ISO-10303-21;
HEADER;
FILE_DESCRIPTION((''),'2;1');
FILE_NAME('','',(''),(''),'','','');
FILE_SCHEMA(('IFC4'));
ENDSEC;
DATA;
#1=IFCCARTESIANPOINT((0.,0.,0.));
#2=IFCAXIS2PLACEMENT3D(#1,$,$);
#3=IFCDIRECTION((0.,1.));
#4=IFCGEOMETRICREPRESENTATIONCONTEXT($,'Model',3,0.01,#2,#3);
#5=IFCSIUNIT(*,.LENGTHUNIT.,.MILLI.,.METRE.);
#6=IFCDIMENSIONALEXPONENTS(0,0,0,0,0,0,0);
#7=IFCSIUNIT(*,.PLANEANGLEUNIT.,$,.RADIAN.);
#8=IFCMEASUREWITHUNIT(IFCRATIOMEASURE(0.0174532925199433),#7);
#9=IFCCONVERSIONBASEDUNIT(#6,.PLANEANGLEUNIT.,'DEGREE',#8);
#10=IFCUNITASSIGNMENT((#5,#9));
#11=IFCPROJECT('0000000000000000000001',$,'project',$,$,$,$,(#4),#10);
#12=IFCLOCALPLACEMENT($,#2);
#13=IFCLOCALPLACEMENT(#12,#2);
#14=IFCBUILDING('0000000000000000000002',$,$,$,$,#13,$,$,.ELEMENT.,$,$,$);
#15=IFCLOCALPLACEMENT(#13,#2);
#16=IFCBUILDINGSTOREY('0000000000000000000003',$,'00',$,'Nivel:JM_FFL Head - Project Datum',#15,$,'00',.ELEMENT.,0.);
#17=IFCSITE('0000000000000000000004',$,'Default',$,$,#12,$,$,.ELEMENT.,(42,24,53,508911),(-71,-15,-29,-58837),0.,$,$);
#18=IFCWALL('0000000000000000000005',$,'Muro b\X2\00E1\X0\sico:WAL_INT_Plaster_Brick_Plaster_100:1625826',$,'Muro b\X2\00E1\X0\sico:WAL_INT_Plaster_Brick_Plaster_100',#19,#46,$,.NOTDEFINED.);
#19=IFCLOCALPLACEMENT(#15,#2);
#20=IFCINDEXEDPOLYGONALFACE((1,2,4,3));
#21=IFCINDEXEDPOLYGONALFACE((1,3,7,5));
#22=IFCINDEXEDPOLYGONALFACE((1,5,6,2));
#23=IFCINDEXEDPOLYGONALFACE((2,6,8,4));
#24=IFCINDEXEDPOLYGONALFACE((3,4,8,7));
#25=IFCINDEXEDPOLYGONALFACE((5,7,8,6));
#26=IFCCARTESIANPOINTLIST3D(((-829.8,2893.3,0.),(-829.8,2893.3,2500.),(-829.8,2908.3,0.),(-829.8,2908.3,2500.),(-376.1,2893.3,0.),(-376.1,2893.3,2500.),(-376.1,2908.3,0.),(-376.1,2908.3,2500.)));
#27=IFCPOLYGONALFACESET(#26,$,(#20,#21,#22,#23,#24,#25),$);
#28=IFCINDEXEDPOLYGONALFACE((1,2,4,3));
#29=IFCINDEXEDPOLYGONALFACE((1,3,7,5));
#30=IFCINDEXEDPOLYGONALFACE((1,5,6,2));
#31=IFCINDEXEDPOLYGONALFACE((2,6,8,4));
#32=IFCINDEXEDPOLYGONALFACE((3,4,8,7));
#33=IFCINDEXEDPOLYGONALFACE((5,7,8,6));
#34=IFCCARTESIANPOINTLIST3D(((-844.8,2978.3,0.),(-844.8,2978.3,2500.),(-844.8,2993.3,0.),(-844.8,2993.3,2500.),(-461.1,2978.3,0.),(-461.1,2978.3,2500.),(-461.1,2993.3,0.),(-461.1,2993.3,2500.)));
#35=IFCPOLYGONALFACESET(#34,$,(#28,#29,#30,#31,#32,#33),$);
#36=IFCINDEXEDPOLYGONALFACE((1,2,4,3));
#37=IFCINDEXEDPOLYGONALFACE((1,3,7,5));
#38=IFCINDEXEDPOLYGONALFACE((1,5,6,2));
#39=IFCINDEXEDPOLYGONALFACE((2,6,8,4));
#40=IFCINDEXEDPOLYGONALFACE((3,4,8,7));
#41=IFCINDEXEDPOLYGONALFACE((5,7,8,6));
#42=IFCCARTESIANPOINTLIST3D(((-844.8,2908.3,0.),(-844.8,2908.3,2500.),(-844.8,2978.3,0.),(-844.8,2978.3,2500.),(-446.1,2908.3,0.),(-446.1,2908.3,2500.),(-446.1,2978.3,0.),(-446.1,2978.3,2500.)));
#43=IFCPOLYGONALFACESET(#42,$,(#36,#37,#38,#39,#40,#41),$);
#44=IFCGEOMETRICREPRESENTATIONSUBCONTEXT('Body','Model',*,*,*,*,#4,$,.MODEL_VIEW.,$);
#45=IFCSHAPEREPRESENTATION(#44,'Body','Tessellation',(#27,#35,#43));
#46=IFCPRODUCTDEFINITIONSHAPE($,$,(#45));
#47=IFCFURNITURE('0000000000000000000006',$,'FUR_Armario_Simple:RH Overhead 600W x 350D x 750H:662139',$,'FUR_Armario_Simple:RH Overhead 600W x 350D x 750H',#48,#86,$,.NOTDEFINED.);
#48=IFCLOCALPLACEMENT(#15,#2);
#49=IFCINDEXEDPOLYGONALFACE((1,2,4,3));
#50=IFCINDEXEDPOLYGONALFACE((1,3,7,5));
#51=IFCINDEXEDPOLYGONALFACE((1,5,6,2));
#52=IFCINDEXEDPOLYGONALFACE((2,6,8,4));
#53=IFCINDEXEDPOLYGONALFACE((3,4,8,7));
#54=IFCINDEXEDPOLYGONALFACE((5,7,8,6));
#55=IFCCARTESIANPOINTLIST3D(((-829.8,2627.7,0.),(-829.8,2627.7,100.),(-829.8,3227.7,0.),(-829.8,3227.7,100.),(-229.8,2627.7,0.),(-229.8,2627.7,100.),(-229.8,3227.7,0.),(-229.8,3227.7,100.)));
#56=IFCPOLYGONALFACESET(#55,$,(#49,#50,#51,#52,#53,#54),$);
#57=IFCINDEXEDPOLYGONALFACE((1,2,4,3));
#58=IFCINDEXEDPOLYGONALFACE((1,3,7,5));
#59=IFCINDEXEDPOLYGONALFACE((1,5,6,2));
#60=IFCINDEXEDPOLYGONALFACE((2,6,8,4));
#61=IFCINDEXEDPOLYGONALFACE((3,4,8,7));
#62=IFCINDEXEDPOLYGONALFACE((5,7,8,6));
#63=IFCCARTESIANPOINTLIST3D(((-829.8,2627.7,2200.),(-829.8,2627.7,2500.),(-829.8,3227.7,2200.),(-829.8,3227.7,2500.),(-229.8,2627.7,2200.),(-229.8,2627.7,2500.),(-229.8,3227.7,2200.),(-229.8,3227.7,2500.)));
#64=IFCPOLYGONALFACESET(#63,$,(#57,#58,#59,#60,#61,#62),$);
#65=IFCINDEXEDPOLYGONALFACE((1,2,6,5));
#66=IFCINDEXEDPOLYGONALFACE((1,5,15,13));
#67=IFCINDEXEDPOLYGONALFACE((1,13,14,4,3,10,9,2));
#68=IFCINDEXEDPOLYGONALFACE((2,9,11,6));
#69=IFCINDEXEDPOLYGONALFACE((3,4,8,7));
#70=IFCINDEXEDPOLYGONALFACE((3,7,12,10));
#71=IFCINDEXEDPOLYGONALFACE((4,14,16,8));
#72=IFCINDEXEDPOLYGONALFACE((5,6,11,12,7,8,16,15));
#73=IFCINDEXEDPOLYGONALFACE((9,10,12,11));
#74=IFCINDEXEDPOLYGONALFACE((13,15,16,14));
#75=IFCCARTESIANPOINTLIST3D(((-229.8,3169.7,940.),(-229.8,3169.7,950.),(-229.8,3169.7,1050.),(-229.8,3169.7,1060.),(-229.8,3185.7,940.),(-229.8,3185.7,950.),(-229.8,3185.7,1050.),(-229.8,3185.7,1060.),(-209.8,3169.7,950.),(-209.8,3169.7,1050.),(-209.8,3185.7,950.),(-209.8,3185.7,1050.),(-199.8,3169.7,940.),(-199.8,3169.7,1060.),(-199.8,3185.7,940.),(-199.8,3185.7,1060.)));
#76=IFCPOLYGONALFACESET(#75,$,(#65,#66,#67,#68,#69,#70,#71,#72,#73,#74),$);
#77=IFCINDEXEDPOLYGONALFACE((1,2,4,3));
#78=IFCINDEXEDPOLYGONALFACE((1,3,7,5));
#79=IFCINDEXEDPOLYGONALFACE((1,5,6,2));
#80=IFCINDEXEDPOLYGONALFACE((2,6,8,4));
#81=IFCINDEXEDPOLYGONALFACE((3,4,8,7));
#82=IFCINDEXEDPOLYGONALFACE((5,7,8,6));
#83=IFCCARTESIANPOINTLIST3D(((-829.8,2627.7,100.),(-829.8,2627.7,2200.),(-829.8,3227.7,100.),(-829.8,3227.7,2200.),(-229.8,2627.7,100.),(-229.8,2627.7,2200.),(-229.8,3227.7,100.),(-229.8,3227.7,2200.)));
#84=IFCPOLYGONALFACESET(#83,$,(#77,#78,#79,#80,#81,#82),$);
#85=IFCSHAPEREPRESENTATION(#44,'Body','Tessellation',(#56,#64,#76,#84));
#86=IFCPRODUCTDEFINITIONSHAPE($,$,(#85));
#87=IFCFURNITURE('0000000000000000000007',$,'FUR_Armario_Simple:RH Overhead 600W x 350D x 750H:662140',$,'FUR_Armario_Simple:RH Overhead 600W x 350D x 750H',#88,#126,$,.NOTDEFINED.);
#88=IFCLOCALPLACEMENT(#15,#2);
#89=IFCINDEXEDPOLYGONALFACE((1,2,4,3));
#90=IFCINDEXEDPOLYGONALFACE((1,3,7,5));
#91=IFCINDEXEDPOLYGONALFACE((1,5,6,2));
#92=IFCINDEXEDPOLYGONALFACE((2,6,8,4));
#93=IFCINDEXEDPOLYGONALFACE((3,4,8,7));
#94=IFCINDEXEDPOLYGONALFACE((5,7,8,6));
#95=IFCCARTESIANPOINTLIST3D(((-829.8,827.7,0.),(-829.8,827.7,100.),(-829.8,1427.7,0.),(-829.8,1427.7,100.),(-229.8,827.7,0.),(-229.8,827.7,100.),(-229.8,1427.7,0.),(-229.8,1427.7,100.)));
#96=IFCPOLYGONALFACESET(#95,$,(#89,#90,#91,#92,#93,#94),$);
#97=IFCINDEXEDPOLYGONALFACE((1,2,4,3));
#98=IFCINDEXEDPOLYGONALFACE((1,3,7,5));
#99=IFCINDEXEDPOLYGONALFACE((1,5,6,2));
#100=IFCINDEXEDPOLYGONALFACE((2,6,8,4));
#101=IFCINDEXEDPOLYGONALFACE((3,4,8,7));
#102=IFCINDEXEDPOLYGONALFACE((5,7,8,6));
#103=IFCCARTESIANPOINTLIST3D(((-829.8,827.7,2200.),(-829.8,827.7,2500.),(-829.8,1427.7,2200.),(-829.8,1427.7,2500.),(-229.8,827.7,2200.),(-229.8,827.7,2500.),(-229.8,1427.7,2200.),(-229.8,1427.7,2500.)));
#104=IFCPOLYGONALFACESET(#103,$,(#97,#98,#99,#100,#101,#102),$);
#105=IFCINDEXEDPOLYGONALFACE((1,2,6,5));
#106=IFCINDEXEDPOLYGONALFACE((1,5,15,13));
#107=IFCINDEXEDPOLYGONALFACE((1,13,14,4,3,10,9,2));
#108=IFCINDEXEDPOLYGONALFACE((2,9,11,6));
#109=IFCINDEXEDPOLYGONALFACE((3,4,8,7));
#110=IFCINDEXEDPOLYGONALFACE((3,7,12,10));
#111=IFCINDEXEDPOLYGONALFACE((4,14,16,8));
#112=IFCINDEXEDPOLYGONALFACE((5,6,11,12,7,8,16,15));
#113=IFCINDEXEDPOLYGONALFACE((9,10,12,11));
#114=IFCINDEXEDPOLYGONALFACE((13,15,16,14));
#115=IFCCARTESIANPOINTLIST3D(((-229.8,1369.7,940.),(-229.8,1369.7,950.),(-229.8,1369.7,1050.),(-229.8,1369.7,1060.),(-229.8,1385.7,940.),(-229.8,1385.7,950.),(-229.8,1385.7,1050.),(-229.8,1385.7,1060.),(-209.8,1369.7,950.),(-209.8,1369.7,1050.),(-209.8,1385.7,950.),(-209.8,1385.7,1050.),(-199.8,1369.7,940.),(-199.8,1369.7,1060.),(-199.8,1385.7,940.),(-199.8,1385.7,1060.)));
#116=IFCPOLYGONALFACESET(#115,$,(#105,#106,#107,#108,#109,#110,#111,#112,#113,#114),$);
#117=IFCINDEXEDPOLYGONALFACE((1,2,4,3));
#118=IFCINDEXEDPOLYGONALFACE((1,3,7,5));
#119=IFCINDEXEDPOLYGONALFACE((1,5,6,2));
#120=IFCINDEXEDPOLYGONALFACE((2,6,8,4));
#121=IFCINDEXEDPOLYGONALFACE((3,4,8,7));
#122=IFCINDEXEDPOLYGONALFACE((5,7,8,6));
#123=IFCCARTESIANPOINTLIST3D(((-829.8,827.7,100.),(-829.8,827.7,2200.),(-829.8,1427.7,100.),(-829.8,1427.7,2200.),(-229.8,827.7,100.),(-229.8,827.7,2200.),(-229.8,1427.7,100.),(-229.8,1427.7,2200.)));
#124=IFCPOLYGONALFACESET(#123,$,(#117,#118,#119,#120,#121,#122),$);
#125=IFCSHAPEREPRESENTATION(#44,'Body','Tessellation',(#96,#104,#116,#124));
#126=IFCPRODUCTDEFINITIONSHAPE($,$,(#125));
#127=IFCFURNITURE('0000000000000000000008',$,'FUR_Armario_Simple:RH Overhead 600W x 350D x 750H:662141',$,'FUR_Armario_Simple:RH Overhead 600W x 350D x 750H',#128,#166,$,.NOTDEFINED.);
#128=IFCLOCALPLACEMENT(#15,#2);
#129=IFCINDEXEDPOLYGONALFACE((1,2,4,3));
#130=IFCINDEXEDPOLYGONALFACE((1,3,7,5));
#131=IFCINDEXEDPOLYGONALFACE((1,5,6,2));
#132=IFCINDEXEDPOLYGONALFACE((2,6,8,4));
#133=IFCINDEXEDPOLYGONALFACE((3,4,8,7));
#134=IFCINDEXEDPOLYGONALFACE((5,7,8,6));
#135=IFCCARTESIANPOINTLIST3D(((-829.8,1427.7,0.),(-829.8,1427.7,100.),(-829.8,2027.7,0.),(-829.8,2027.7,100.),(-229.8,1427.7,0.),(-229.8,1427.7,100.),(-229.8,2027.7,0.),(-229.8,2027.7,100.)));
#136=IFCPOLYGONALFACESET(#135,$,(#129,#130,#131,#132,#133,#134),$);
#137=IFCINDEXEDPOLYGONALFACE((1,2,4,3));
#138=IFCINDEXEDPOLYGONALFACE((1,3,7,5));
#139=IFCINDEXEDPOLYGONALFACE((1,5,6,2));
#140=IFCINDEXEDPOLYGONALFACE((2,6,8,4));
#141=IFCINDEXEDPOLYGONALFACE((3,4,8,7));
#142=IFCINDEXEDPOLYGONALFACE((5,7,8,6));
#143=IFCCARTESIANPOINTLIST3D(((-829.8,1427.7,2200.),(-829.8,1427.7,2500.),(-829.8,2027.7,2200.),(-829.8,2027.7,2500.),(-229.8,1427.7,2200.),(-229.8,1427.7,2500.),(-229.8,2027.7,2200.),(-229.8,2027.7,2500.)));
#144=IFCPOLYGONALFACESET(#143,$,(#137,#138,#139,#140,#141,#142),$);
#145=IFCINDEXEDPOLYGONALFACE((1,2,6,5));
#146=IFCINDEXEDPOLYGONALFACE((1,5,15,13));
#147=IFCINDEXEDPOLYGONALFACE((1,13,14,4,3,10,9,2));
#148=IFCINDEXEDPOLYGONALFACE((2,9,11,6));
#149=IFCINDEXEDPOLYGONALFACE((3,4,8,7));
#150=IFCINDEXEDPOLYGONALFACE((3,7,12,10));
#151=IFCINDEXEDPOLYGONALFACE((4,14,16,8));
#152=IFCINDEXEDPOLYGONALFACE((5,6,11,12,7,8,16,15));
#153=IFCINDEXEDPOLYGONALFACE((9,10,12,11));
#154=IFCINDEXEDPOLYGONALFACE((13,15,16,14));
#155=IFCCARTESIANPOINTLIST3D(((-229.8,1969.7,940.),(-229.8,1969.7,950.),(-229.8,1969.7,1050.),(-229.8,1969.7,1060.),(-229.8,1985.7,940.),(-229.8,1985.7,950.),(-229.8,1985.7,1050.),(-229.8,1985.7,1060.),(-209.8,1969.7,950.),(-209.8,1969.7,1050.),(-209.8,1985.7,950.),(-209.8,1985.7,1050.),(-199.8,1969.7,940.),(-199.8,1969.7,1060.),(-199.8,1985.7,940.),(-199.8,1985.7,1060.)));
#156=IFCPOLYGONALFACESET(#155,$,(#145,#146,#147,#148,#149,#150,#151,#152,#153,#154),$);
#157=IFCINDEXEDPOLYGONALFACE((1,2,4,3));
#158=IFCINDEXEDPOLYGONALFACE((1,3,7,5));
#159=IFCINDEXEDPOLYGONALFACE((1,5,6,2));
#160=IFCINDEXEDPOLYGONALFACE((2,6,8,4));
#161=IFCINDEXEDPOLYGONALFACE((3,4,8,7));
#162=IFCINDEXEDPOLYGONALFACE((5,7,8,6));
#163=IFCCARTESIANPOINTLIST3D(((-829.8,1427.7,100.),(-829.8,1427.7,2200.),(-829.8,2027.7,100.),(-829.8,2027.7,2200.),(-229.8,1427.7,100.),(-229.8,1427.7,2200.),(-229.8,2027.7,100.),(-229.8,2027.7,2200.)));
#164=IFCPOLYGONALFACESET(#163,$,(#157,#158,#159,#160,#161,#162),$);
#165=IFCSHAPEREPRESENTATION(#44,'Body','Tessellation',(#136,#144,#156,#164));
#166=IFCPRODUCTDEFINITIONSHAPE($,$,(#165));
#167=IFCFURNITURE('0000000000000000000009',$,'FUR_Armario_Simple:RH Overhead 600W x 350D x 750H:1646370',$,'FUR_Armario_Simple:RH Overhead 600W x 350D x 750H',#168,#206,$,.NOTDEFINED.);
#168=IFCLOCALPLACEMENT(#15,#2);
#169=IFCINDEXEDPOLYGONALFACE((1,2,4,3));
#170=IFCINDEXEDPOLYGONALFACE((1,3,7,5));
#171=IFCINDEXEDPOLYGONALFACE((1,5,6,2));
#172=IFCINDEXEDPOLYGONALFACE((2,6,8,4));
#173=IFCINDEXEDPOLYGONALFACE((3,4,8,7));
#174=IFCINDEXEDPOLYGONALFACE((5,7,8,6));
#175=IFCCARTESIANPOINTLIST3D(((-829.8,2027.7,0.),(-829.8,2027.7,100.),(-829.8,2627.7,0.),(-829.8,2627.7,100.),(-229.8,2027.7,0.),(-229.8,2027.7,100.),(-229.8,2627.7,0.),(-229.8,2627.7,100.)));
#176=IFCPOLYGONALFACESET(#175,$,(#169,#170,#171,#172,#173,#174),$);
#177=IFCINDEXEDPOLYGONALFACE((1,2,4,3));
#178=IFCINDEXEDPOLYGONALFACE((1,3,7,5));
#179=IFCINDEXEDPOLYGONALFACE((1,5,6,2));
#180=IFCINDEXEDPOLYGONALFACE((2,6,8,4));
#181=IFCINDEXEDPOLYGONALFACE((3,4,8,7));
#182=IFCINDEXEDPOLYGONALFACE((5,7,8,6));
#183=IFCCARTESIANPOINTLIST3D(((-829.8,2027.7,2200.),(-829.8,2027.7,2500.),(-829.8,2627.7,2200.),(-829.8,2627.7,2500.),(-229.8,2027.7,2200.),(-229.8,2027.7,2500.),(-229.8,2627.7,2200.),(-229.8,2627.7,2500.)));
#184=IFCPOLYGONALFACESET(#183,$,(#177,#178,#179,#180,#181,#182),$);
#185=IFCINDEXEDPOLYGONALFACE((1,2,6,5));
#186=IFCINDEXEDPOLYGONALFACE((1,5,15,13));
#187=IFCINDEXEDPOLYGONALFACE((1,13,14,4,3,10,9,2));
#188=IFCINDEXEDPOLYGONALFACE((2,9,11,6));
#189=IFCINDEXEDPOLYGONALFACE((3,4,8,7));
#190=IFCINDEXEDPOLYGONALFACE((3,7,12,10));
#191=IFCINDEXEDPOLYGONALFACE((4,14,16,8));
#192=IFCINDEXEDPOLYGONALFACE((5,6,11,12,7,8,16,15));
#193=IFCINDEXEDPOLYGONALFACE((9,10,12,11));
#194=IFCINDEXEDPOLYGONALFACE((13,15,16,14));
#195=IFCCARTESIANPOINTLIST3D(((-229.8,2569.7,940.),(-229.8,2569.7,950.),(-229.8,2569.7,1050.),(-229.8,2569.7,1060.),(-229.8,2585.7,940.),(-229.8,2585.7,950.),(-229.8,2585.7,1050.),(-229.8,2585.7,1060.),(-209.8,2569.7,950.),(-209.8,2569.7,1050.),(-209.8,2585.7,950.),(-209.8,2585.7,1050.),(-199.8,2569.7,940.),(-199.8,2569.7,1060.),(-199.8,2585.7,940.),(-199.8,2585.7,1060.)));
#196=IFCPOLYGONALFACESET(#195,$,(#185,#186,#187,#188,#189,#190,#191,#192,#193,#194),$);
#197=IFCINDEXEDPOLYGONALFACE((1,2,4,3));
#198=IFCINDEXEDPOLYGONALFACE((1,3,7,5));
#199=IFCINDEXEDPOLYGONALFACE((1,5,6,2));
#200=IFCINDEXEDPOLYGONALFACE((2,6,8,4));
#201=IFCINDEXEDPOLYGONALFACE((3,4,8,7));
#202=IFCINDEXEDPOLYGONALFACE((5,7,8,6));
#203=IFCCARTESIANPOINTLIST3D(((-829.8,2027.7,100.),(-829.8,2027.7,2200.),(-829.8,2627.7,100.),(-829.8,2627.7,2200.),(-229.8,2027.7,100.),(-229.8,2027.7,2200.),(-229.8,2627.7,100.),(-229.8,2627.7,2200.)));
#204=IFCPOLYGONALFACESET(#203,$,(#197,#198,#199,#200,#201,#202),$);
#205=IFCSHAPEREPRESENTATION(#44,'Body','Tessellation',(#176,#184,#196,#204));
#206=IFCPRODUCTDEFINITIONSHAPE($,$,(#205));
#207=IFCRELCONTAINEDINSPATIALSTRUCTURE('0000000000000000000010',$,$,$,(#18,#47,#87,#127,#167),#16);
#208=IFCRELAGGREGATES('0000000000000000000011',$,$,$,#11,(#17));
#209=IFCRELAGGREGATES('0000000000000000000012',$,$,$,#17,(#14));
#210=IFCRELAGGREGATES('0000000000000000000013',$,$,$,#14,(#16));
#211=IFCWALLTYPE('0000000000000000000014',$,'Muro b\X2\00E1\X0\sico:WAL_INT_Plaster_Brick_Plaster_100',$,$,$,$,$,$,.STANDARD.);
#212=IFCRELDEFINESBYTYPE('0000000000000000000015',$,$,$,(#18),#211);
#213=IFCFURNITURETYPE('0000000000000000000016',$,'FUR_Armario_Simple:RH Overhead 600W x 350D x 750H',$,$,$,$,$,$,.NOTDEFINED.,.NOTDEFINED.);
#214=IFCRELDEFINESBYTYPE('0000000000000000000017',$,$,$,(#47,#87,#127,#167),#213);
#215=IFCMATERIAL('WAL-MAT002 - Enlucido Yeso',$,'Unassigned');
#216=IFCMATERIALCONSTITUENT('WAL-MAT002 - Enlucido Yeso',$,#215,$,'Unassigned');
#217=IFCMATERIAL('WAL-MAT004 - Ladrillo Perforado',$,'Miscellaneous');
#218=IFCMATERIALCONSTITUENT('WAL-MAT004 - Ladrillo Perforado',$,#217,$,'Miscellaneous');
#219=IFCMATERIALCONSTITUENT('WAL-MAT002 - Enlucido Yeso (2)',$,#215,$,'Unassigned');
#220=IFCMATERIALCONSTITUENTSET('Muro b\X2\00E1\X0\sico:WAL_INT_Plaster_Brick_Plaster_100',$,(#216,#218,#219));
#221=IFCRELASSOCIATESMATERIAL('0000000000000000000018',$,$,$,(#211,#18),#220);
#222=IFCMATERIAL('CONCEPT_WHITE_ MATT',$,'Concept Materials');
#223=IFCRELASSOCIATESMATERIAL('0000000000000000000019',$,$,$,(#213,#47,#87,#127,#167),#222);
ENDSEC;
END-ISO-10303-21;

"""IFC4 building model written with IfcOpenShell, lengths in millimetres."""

from ifc_helpers import new_model, entity, si_unit, converted_unit, direction, frame, origin, place, context, subcontext, project, spatial, indexed_curve, outline, extrude, source, transform, mapped, material, constituent, constituent_set, type_object, type_shapes, element, save


model = new_model("IFC4")

# Units and contexts
model_context = context("Model", 3, precision=0.01, world=origin(), true_north=direction((0.0, 1.0)))
body_context = subcontext(model_context, "Body", "Model", "MODEL_VIEW")
ifc_project = project(units=[si_unit("LENGTHUNIT", "METRE", prefix="MILLI"), converted_unit("PLANEANGLEUNIT", "DEGREE", entity("IfcRatioMeasure", 0.0174532925199433), si_unit("PLANEANGLEUNIT", "RADIAN"), dimensions=[0, 0, 0, 0, 0, 0, 0])], contexts=[model_context])

# Site, building, storey
site_placement = place(None, origin())
site = spatial("IfcSite", under=ifc_project, at=site_placement, Name="Default", CompositionType="ELEMENT", RefLatitude=(42, 24, 53, 508911), RefLongitude=(-71, -15, -29, -58837), RefElevation=0.0)
building_placement = place(site_placement, origin())
building = spatial("IfcBuilding", under=site, at=building_placement, CompositionType="ELEMENT")
storey_placement = place(building_placement, origin())
storey = spatial("IfcBuildingStorey", under=building, at=storey_placement, Name="00", ObjectType="Nivel:JM_FFL Head - Project Datum", LongName="00", CompositionType="ELEMENT", Elevation=0.0)

# Shared definitions
ifc_material_1 = material(Name="CONCEPT_WHITE_ MATT", Category="Concept Materials")

# Wall
ifc_material_2 = material(Name="WAL-MAT004 - Ladrillo Perforado", Category="Miscellaneous")
ifc_material_3 = material(Name="WAL-MAT002 - Enlucido Yeso", Category="Unassigned")
ifc_constituent_1 = constituent(ifc_material_3, Name="WAL-MAT002 - Enlucido Yeso", Category="Unassigned")
ifc_constituent_2 = constituent(ifc_material_2, Name="WAL-MAT004 - Ladrillo Perforado", Category="Miscellaneous")
ifc_constituent_3 = constituent(ifc_material_3, Name="WAL-MAT002 - Enlucido Yeso (2)", Category="Unassigned")
ifc_constituent_set_1 = constituent_set(constituents=[ifc_constituent_1, ifc_constituent_2, ifc_constituent_3], Name="Muro básico:WAL_INT_Plaster_Brick_Plaster_100")
wall_type_1 = type_object("IfcWallType", Name="Muro básico:WAL_INT_Plaster_Brick_Plaster_100", PredefinedType="STANDARD", material=ifc_constituent_set_1)
wall_1_placement = place(storey_placement, frame((-461.1, 2943.3, 0.0), z_axis=(0.0, 0.0, 1.0), x_axis=(-1.0, 0.0, 0.0)))
element("IfcWall", 1, at=wall_1_placement, inside=storey, type_object=wall_type_1, material=ifc_constituent_set_1, Name="Muro básico:WAL_INT_Plaster_Brick_Plaster_100:1625826", ObjectType="Muro básico:WAL_INT_Plaster_Brick_Plaster_100", PredefinedType="NOTDEFINED", context=body_context, shape_type="SweptSolid", body=[
    extrude(outline(indexed_curve([(-7.5, -226.9), (7.5, -226.9), (7.5, 226.9), (-7.5, 226.9), (-7.5, -226.9)], self_intersect=False)), frame((141.9, 42.5, 0.0), z_axis=(0.0, 0.0, 1.0), x_axis=(0.0, -1.0, 0.0)), (0.0, 0.0, 1.0), 2500.0),
    extrude(outline(indexed_curve([(-7.5, -191.9), (7.5, -191.9), (7.5, 191.9), (-7.5, 191.9), (-7.5, -191.9)], self_intersect=False)), frame((191.9, -42.5, 0.0), z_axis=(0.0, 0.0, 1.0), x_axis=(0.0, 1.0, 0.0)), (0.0, 0.0, 1.0), 2500.0),
    extrude(outline(indexed_curve([(-199.4, -35.0), (199.4, -35.0), (199.4, 35.0), (-199.4, 35.0), (-199.4, -35.0)], self_intersect=False)), frame((184.4, 0.0, 0.0)), (0.0, 0.0, 1.0), 2500.0),
])

# Furniture
furniture_type_1 = type_object("IfcFurnitureType", Name="FUR_Armario_Simple:RH Overhead 600W x 350D x 750H", AssemblyPlace="NOTDEFINED", PredefinedType="NOTDEFINED", material=ifc_material_1)
shared_shape_1 = source(origin(), body_context, "Body", "SweptSolid", [
    extrude(outline(indexed_curve([(-300.0, -300.0), (300.0, -300.0), (300.0, 300.0), (-300.0, 300.0), (-300.0, -300.0)], self_intersect=False)), frame((300.0, -300.0, 0.0), z_axis=(0.0, 0.0, 1.0), x_axis=(-1.0, 0.0, 0.0)), (0.0, 0.0, 1.0), 100.0),
    extrude(outline(indexed_curve([(-300.0, -300.0), (300.0, -300.0), (300.0, 300.0), (-300.0, 300.0), (-300.0, -300.0)], self_intersect=False)), frame((300.0, -300.0, 2200.0), z_axis=(0.0, 0.0, 1.0), x_axis=(-1.0, 0.0, 0.0)), (0.0, 0.0, 1.0), 300.0),
    extrude(outline(indexed_curve([(-60.0, -17.5), (60.0, -17.5), (60.0, 12.5), (50.0, 12.5), (50.0, -7.5), (-50.0, -7.5), (-50.0, 12.5), (-60.0, 12.5), (-60.0, -17.5)], self_intersect=False)), frame((542.0, -612.5, 1000.0), z_axis=(1.0, 0.0, 0.0), x_axis=(0.0, 0.0, -1.0)), (0.0, 0.0, 1.0), 16.0),
    extrude(outline(indexed_curve([(-300.0, -300.0), (300.0, -300.0), (300.0, 300.0), (-300.0, 300.0), (-300.0, -300.0)], self_intersect=False)), frame((300.0, -300.0, 100.0), z_axis=(0.0, 0.0, 1.0), x_axis=(0.0, 1.0, 0.0)), (0.0, 0.0, 1.0), 2100.0),
])
type_shapes(furniture_type_1, [shared_shape_1])
for number, where, z_axis, x_axis, name in (
    (2, (-829.8, 2627.7, 0.0), (0.0, 0.0, 1.0), (0.0, 1.0, 0.0), "FUR_Armario_Simple:RH Overhead 600W x 350D x 750H:662139"),
    (3, (-829.8, 827.7, 0.0), (0.0, 0.0, 1.0), (0.0, 1.0, 0.0), "FUR_Armario_Simple:RH Overhead 600W x 350D x 750H:662140"),
    (4, (-829.8, 1427.7, 0.0), (0.0, 0.0, 1.0), (0.0, 1.0, 0.0), "FUR_Armario_Simple:RH Overhead 600W x 350D x 750H:662141"),
    (5, (-829.8, 2027.7, 0.0), (0.0, 0.0, 1.0), (0.0, 1.0, 0.0), "FUR_Armario_Simple:RH Overhead 600W x 350D x 750H:1646370"),
):
    element("IfcFurniture", number, at=place(storey_placement, frame(where, z_axis=z_axis, x_axis=x_axis)), inside=storey, type_object=furniture_type_1, material=ifc_material_1, Name=name, ObjectType="FUR_Armario_Simple:RH Overhead 600W x 350D x 750H", PredefinedType="NOTDEFINED", context=body_context, shape_type="MappedRepresentation", body=[
        mapped(shared_shape_1, transform((0.0, 0.0, 0.0), scale=1.0)),
    ])

save(model, "model.ifc")
